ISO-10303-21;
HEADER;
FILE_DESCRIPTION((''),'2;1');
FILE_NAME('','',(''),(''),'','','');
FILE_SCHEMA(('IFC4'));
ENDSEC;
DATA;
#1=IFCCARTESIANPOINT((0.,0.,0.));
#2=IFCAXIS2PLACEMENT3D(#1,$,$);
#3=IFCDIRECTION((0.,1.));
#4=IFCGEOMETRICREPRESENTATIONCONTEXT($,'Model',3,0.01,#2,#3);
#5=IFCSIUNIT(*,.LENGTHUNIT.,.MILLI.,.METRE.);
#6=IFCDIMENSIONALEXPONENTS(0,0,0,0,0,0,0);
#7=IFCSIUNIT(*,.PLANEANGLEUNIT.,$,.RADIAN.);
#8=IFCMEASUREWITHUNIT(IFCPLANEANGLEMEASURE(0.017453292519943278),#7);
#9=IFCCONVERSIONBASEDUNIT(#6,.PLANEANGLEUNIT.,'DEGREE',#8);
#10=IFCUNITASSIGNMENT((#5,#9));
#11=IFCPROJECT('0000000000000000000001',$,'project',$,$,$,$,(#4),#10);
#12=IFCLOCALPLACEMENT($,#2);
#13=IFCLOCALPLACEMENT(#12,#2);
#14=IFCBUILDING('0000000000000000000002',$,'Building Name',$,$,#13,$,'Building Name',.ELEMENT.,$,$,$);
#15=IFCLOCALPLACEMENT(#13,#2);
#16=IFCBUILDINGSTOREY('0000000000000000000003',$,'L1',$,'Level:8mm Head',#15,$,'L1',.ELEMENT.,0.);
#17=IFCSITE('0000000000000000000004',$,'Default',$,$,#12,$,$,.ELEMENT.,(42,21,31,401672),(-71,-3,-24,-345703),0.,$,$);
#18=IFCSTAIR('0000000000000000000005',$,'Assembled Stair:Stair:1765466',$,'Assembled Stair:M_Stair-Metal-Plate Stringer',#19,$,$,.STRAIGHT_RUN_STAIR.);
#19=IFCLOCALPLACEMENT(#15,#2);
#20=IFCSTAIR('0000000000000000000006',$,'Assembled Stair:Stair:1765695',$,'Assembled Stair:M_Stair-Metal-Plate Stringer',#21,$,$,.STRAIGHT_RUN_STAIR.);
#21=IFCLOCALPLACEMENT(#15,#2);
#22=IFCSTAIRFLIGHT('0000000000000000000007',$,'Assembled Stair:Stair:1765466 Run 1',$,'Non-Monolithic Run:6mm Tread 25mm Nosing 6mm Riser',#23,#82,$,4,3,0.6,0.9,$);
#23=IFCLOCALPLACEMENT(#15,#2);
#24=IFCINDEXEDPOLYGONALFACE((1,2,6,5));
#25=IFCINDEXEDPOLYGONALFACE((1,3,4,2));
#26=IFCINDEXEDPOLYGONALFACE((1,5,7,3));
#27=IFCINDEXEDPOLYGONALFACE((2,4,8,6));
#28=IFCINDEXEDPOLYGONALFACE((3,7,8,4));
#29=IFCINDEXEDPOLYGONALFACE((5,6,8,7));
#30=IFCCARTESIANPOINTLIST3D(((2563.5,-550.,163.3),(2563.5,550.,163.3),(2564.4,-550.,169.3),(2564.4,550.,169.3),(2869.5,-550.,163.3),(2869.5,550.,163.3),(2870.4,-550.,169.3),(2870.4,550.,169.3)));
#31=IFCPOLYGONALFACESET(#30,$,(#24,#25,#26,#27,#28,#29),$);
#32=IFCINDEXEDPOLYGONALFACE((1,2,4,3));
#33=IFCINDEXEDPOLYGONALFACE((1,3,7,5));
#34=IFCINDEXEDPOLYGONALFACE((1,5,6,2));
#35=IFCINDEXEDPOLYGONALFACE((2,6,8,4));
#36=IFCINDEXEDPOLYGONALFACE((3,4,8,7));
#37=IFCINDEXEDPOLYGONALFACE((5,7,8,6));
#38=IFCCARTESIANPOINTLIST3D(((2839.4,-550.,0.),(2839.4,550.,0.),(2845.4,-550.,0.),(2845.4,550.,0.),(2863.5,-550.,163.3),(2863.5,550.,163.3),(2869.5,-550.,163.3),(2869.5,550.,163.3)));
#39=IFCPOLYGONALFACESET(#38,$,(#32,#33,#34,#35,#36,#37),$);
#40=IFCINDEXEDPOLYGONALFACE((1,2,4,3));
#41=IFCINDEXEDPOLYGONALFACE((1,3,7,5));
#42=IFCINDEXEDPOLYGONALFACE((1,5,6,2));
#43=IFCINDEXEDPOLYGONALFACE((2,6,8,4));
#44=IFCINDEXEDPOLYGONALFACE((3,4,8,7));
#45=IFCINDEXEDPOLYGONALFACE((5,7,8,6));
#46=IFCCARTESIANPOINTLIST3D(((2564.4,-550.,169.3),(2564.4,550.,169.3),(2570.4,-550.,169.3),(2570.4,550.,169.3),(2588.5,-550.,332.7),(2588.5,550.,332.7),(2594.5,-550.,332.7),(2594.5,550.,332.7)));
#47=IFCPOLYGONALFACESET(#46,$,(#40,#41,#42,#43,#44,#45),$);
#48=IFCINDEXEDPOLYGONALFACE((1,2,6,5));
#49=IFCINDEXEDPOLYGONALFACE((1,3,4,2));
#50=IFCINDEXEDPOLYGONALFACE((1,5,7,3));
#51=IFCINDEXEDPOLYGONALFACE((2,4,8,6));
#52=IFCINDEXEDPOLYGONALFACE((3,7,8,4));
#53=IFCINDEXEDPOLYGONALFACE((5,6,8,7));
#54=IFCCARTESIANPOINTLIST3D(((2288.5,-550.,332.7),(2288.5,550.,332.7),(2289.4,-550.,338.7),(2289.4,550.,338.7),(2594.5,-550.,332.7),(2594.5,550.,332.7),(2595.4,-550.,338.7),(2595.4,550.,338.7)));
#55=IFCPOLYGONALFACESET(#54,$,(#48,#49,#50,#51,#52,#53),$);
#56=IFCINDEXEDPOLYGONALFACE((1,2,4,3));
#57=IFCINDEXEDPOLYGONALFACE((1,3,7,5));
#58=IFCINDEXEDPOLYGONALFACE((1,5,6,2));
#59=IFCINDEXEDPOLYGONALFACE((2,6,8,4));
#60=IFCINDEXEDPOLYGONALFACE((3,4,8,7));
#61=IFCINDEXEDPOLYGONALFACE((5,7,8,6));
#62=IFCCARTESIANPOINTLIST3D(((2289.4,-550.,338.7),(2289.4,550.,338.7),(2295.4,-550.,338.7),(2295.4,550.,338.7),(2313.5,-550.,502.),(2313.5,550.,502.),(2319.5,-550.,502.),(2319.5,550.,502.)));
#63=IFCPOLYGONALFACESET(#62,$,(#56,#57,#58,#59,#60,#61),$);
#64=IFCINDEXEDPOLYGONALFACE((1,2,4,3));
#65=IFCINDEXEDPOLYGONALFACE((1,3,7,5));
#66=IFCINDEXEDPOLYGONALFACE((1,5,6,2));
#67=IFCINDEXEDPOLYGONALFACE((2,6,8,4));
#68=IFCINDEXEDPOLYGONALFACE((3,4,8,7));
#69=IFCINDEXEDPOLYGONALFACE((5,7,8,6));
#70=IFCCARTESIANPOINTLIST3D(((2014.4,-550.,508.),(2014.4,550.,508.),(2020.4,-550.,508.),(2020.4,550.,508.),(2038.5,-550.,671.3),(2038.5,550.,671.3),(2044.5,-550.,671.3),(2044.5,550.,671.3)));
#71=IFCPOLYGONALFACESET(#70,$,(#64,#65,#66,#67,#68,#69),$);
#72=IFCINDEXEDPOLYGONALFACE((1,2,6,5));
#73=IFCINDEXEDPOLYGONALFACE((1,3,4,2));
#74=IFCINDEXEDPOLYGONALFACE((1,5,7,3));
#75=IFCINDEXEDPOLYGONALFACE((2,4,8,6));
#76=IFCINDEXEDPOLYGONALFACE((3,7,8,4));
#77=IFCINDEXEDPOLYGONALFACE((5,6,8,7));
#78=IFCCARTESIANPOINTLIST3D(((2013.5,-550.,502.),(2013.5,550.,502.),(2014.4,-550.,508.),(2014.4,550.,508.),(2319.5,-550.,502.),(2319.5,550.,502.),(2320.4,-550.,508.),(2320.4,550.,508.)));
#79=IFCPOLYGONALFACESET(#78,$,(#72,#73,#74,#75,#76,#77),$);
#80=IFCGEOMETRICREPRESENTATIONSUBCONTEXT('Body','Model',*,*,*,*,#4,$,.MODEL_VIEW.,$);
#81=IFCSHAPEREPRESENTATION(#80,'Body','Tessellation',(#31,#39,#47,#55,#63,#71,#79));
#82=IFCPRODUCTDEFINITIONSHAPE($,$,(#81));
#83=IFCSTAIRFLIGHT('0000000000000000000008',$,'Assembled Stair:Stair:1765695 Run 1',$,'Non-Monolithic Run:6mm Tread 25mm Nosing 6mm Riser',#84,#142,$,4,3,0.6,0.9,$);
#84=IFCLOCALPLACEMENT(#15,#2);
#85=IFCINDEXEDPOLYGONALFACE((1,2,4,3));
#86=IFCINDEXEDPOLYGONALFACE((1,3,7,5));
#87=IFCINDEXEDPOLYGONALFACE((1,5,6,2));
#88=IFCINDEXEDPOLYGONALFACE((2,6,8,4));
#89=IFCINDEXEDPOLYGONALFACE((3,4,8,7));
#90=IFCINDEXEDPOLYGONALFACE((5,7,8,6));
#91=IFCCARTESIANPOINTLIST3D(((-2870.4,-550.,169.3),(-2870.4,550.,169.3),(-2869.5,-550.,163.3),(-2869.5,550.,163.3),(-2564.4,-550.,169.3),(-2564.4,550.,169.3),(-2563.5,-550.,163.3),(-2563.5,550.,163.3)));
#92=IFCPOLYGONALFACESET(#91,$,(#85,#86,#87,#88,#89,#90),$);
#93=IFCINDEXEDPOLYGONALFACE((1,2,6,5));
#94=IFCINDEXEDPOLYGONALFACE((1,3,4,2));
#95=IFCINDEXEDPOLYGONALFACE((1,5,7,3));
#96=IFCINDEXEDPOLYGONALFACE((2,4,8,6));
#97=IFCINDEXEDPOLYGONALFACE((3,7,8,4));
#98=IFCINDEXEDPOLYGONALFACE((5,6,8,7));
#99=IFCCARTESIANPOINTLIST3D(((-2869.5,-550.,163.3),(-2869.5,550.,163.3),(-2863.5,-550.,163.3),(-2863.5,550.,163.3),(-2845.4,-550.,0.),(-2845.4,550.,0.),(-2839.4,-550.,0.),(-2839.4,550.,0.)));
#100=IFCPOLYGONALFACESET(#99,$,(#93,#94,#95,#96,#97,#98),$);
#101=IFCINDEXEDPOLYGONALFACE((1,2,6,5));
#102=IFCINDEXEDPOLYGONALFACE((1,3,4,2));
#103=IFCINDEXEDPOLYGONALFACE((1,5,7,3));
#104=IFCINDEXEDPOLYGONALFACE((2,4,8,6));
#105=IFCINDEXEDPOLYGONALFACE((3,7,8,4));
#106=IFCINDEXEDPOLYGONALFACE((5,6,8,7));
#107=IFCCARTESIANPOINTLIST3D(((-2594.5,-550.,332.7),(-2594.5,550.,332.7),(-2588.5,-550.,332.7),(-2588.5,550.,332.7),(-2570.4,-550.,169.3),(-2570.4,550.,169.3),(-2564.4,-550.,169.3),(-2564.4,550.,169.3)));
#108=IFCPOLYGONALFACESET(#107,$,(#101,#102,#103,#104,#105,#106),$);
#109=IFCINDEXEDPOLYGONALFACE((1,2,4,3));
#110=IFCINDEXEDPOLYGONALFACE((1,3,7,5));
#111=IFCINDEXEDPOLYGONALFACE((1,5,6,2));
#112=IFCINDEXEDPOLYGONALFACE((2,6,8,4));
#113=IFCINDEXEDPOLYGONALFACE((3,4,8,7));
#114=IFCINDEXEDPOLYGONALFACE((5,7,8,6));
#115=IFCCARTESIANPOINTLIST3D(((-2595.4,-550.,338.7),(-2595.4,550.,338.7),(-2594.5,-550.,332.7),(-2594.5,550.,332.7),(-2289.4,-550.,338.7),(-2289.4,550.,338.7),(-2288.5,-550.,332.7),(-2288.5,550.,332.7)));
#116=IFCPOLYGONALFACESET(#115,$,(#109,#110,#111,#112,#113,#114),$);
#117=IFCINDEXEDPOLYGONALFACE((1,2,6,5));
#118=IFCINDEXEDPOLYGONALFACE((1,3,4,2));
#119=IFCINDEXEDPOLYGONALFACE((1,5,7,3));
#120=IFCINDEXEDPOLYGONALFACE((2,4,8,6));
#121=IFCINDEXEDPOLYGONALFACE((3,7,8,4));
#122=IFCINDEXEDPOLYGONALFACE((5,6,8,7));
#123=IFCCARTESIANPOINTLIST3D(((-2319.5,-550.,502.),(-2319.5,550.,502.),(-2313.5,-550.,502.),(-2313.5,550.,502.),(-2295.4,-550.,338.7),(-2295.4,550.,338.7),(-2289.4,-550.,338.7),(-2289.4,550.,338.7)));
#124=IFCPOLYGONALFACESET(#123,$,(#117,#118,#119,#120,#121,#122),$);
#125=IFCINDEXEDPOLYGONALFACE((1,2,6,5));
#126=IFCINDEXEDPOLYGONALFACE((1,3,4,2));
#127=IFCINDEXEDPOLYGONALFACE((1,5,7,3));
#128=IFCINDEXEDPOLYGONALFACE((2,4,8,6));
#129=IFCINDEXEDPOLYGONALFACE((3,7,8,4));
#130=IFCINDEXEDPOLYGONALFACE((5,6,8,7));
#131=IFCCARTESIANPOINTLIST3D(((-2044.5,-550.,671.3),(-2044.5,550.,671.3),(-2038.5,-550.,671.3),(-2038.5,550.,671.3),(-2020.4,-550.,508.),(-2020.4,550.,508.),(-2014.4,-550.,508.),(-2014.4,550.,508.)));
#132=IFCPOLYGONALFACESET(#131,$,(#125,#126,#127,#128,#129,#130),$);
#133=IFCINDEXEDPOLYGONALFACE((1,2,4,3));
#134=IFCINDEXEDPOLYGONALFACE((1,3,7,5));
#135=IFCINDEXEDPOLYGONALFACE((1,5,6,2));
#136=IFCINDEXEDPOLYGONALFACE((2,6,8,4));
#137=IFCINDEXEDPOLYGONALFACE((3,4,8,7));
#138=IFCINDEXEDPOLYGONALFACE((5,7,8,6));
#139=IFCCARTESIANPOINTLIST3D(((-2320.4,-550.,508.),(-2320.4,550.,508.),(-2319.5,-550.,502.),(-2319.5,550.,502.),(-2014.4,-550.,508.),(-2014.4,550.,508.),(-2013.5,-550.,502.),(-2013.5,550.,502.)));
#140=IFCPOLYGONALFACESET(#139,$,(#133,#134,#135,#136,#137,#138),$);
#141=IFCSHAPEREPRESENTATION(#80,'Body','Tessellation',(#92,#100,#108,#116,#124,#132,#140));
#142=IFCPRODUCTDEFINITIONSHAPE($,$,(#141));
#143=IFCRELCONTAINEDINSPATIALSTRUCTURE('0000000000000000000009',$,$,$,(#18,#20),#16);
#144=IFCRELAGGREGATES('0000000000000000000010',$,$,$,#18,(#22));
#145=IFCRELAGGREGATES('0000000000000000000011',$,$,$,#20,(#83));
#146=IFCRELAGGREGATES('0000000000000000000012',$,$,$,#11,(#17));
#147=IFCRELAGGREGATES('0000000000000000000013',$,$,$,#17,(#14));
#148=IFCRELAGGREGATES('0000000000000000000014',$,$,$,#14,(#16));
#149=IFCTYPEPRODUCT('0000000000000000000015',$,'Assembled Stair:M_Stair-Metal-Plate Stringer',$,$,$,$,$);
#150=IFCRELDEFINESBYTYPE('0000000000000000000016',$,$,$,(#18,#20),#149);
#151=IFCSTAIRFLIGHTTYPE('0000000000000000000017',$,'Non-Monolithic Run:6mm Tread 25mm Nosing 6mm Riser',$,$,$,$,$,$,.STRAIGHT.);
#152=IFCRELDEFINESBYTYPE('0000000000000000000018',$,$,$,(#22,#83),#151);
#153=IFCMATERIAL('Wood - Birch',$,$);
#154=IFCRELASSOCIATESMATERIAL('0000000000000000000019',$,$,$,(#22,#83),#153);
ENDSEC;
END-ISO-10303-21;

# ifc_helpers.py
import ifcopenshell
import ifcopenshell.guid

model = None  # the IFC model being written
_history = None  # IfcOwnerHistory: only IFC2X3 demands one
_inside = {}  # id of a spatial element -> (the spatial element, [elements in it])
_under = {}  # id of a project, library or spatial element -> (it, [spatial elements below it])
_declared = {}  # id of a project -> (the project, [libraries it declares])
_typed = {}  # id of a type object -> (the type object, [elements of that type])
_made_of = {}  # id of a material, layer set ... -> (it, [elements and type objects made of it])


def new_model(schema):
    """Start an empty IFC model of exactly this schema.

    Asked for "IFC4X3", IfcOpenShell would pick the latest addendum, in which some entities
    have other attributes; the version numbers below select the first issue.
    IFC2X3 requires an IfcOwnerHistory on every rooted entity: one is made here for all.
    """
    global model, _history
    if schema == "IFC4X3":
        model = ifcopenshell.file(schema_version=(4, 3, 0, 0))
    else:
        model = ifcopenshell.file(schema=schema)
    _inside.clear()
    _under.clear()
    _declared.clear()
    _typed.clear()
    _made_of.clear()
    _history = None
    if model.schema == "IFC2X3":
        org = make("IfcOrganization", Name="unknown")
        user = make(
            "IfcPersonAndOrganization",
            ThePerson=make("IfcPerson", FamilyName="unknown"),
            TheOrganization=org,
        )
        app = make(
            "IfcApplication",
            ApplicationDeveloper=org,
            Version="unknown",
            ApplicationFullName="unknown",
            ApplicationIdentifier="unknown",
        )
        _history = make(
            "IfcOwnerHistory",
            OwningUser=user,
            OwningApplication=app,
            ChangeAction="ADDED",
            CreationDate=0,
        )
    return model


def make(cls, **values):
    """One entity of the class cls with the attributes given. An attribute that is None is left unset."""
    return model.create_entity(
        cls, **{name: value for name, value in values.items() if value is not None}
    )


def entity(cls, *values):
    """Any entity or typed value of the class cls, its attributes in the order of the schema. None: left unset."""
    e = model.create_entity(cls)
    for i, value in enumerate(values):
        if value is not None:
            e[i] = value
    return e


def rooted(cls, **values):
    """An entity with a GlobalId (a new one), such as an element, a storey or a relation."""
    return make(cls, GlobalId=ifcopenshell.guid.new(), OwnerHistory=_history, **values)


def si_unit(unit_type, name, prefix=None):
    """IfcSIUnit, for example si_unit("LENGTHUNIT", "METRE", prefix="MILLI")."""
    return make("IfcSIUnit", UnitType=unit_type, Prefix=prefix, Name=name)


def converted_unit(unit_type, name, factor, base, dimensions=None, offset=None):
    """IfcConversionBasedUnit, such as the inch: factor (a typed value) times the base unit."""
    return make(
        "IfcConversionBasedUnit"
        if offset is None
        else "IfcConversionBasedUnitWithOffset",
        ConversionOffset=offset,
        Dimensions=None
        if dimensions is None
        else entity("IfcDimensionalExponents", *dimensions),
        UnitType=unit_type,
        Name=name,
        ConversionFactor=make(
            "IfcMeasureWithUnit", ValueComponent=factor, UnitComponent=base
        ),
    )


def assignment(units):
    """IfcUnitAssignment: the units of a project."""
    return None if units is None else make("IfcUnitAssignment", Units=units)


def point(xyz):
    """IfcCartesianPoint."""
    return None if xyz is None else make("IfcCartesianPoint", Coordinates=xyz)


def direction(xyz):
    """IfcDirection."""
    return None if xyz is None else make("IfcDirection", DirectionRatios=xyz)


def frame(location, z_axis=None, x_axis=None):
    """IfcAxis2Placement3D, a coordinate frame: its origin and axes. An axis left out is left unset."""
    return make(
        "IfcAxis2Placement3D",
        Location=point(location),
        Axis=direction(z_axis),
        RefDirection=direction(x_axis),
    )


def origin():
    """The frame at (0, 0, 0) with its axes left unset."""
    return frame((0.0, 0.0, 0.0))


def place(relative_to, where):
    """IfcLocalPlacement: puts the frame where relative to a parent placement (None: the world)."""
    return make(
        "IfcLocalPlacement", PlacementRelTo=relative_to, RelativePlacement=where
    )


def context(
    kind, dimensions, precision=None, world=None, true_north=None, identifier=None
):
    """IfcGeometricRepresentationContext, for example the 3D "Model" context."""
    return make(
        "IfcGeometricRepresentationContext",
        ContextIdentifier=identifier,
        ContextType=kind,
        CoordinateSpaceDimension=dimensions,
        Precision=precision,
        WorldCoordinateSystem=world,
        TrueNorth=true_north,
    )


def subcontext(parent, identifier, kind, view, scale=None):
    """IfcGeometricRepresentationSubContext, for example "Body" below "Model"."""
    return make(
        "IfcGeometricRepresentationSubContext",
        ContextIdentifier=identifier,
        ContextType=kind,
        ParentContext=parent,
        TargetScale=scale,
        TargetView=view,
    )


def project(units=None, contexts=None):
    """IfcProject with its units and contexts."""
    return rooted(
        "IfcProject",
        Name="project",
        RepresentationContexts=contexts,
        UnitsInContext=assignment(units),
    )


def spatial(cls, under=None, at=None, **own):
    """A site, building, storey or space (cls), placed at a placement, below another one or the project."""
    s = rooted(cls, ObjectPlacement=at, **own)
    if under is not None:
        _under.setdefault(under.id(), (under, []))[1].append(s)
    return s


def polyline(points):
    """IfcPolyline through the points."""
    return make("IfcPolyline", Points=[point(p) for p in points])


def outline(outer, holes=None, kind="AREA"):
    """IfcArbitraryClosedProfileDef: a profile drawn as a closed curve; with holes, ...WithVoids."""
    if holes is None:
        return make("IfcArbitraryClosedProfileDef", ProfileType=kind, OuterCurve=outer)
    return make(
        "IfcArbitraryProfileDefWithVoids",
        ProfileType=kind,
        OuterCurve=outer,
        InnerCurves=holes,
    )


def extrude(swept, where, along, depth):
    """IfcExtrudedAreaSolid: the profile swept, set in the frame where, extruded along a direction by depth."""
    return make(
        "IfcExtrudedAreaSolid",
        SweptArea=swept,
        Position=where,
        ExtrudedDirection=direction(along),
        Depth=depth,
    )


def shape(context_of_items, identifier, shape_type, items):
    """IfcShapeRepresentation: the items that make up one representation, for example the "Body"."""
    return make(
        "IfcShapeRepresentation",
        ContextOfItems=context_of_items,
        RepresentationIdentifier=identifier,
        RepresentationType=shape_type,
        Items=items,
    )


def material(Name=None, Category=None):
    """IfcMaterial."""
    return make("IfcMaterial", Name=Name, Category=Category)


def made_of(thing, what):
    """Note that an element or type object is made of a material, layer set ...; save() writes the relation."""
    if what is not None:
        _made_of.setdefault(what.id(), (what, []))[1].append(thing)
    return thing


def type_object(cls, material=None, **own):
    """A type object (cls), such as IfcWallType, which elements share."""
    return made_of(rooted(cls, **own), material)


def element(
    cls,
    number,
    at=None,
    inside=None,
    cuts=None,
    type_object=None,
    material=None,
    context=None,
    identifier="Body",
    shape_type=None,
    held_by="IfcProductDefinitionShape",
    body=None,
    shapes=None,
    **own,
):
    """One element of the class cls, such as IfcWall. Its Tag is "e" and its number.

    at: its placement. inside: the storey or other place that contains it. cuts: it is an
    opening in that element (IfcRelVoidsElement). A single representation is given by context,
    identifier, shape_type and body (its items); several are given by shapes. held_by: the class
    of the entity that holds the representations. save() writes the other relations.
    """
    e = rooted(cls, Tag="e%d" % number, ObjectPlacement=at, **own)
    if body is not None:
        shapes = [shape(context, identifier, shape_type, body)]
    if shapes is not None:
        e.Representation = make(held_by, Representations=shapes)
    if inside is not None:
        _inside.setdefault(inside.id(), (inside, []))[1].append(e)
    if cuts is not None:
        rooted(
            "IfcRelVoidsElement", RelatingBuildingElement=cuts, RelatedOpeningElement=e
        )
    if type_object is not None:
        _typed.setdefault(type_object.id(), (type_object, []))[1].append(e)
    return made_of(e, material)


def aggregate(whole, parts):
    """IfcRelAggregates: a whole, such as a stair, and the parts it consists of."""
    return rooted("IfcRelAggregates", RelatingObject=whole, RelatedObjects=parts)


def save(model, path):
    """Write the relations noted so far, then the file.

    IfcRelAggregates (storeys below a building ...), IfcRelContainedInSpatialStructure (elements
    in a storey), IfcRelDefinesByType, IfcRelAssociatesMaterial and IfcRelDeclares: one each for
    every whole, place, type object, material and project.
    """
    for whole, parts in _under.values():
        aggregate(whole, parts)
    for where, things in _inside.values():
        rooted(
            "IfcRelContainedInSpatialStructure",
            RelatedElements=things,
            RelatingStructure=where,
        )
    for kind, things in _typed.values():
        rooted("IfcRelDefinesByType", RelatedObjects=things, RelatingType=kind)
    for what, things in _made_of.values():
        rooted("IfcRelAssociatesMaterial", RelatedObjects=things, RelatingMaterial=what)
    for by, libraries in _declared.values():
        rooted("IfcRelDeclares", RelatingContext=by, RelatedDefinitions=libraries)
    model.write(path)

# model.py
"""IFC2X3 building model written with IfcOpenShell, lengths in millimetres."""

from ifc_helpers import new_model, entity, si_unit, converted_unit, direction, frame, origin, place, context, subcontext, project, spatial, polyline, outline, extrude, material, type_object, element, aggregate, save


model = new_model("IFC2X3")

# Units and contexts
model_context = context("Model", 3, precision=0.01, world=origin(), true_north=direction((0.0, 1.0)))
body_context = subcontext(model_context, "Body", "Model", "MODEL_VIEW")
ifc_project = project(units=[si_unit("LENGTHUNIT", "METRE", prefix="MILLI"), converted_unit("PLANEANGLEUNIT", "DEGREE", entity("IfcPlaneAngleMeasure", 0.017453292519943278), si_unit("PLANEANGLEUNIT", "RADIAN"), dimensions=[0, 0, 0, 0, 0, 0, 0])], contexts=[model_context])

# Site, building, storey
site_placement = place(None, origin())
site = spatial("IfcSite", under=ifc_project, at=site_placement, Name="Default", CompositionType="ELEMENT", RefLatitude=(42, 21, 31, 401672), RefLongitude=(-71, -3, -24, -345703), RefElevation=0.0)
building_placement = place(site_placement, origin())
building = spatial("IfcBuilding", under=site, at=building_placement, Name="Building Name", LongName="Building Name", CompositionType="ELEMENT")
storey_placement = place(building_placement, origin())
storey = spatial("IfcBuildingStorey", under=building, at=storey_placement, Name="L1", ObjectType="Level:8mm Head", LongName="L1", CompositionType="ELEMENT", Elevation=0.0)

# Stairs
type_product = type_object("IfcTypeProduct", Name="Assembled Stair:M_Stair-Metal-Plate Stringer")
stair_1_placement = place(storey_placement, origin())
stair_1 = element("IfcStair", 1, at=stair_1_placement, inside=storey, type_object=type_product, Name="Assembled Stair:Stair:1765466", ObjectType="Assembled Stair:M_Stair-Metal-Plate Stringer", ShapeType="STRAIGHT_RUN_STAIR")
ifc_material_1 = material(Name="Wood - Birch")
stair_2_placement = place(storey_placement, origin())
stair_2 = element("IfcStair", 2, at=stair_2_placement, inside=storey, type_object=type_product, Name="Assembled Stair:Stair:1765695", ObjectType="Assembled Stair:M_Stair-Metal-Plate Stringer", ShapeType="STRAIGHT_RUN_STAIR")

# Stair flights
stair_flight_type = type_object("IfcStairFlightType", Name="Non-Monolithic Run:6mm Tread 25mm Nosing 6mm Riser", PredefinedType="STRAIGHT")
stair_flight_1_placement = place(stair_1_placement, origin())
stair_flight_1 = element("IfcStairFlight", 3, at=stair_flight_1_placement, type_object=stair_flight_type, material=ifc_material_1, Name="Assembled Stair:Stair:1765466 Run 1", ObjectType="Non-Monolithic Run:6mm Tread 25mm Nosing 6mm Riser", NumberOfRiser=4, NumberOfTreads=3, RiserHeight=0.6, TreadLength=0.9, context=body_context, shape_type="SweptSolid", body=[
    extrude(outline(polyline([(-25.4, -151.4), (-19.3, -151.4), (25.4, 151.4), (19.3, 151.4), (-25.4, -151.4)])), frame((2717.0, -550.0, 166.3), z_axis=(0.0, 1.0, 0.0), x_axis=(-0.146055, 0.0, -0.989277)), (0.0, 0.0, 1.0), 1100.0),
    extrude(outline(polyline([(-83.0, -3.0), (82.1, -3.0), (83.0, 3.0), (-82.1, 3.0), (-83.0, -3.0)])), frame((2854.5, -550.0, 81.7), z_axis=(0.0, 1.0, 0.0), x_axis=(-0.146055, 0.0, -0.989277)), (0.0, 0.0, 1.0), 1100.0),
    extrude(outline(polyline([(-83.0, -3.0), (82.1, -3.0), (83.0, 3.0), (-82.1, 3.0), (-83.0, -3.0)])), frame((2579.5, -550.0, 251.0), z_axis=(0.0, 1.0, 0.0), x_axis=(-0.146055, 0.0, -0.989277)), (0.0, 0.0, 1.0), 1100.0),
    extrude(outline(polyline([(-25.4, -151.4), (-19.3, -151.4), (25.4, 151.4), (19.3, 151.4), (-25.4, -151.4)])), frame((2442.0, -550.0, 335.7), z_axis=(0.0, 1.0, 0.0), x_axis=(-0.146055, 0.0, -0.989277)), (0.0, 0.0, 1.0), 1100.0),
    extrude(outline(polyline([(-83.0, -3.0), (82.1, -3.0), (83.0, 3.0), (-82.1, 3.0), (-83.0, -3.0)])), frame((2304.5, -550.0, 420.3), z_axis=(0.0, 1.0, 0.0), x_axis=(-0.146055, 0.0, -0.989277)), (0.0, 0.0, 1.0), 1100.0),
    extrude(outline(polyline([(-83.0, -3.0), (82.1, -3.0), (83.0, 3.0), (-82.1, 3.0), (-83.0, -3.0)])), frame((2029.5, -550.0, 589.7), z_axis=(0.0, 1.0, 0.0), x_axis=(-0.146055, 0.0, -0.989277)), (0.0, 0.0, 1.0), 1100.0),
    extrude(outline(polyline([(-25.4, -151.4), (-19.3, -151.4), (25.4, 151.4), (19.3, 151.4), (-25.4, -151.4)])), frame((2167.0, -550.0, 505.0), z_axis=(0.0, 1.0, 0.0), x_axis=(-0.146055, 0.0, -0.989277)), (0.0, 0.0, 1.0), 1100.0),
])
stair_flight_2_placement = place(stair_2_placement, origin())
stair_flight_2 = element("IfcStairFlight", 4, at=stair_flight_2_placement, type_object=stair_flight_type, material=ifc_material_1, Name="Assembled Stair:Stair:1765695 Run 1", ObjectType="Non-Monolithic Run:6mm Tread 25mm Nosing 6mm Riser", NumberOfRiser=4, NumberOfTreads=3, RiserHeight=0.6, TreadLength=0.9, context=body_context, shape_type="SweptSolid", body=[
    extrude(outline(polyline([(19.3, -151.4), (25.4, -151.4), (-19.3, 151.4), (-25.4, 151.4), (19.3, -151.4)])), frame((-2717.0, -550.0, 166.3), z_axis=(0.0, 1.0, 0.0), x_axis=(0.146055, 0.0, -0.989277)), (0.0, 0.0, 1.0), 1100.0),
    extrude(outline(polyline([(-15.1, -81.7), (-9.0, -81.7), (15.1, 81.7), (9.0, 81.7), (-15.1, -81.7)])), frame((-2854.5, -550.0, 81.7), z_axis=(0.0, 1.0, 0.0), x_axis=(1.0, 0.0, 0.0)), (0.0, 0.0, 1.0), 1100.0),
    extrude(outline(polyline([(-15.1, -81.7), (-9.0, -81.7), (15.1, 81.7), (9.0, 81.7), (-15.1, -81.7)])), frame((-2579.5, -550.0, 251.0), z_axis=(0.0, 1.0, 0.0), x_axis=(1.0, 0.0, 0.0)), (0.0, 0.0, 1.0), 1100.0),
    extrude(outline(polyline([(19.3, -151.4), (25.4, -151.4), (-19.3, 151.4), (-25.4, 151.4), (19.3, -151.4)])), frame((-2442.0, -550.0, 335.7), z_axis=(0.0, 1.0, 0.0), x_axis=(0.146055, 0.0, -0.989277)), (0.0, 0.0, 1.0), 1100.0),
    extrude(outline(polyline([(-15.1, -81.7), (-9.0, -81.7), (15.1, 81.7), (9.0, 81.7), (-15.1, -81.7)])), frame((-2304.5, -550.0, 420.3), z_axis=(0.0, 1.0, 0.0), x_axis=(1.0, 0.0, 0.0)), (0.0, 0.0, 1.0), 1100.0),
    extrude(outline(polyline([(-15.1, -81.7), (-9.0, -81.7), (15.1, 81.7), (9.0, 81.7), (-15.1, -81.7)])), frame((-2029.5, -550.0, 589.7), z_axis=(0.0, 1.0, 0.0), x_axis=(1.0, 0.0, 0.0)), (0.0, 0.0, 1.0), 1100.0),
    extrude(outline(polyline([(19.3, -151.4), (25.4, -151.4), (-19.3, 151.4), (-25.4, 151.4), (19.3, -151.4)])), frame((-2167.0, -550.0, 505.0), z_axis=(0.0, 1.0, 0.0), x_axis=(0.146055, 0.0, -0.989277)), (0.0, 0.0, 1.0), 1100.0),
])

aggregate(stair_1, [stair_flight_1])
aggregate(stair_2, [stair_flight_2])

save(model, "model.ifc")
